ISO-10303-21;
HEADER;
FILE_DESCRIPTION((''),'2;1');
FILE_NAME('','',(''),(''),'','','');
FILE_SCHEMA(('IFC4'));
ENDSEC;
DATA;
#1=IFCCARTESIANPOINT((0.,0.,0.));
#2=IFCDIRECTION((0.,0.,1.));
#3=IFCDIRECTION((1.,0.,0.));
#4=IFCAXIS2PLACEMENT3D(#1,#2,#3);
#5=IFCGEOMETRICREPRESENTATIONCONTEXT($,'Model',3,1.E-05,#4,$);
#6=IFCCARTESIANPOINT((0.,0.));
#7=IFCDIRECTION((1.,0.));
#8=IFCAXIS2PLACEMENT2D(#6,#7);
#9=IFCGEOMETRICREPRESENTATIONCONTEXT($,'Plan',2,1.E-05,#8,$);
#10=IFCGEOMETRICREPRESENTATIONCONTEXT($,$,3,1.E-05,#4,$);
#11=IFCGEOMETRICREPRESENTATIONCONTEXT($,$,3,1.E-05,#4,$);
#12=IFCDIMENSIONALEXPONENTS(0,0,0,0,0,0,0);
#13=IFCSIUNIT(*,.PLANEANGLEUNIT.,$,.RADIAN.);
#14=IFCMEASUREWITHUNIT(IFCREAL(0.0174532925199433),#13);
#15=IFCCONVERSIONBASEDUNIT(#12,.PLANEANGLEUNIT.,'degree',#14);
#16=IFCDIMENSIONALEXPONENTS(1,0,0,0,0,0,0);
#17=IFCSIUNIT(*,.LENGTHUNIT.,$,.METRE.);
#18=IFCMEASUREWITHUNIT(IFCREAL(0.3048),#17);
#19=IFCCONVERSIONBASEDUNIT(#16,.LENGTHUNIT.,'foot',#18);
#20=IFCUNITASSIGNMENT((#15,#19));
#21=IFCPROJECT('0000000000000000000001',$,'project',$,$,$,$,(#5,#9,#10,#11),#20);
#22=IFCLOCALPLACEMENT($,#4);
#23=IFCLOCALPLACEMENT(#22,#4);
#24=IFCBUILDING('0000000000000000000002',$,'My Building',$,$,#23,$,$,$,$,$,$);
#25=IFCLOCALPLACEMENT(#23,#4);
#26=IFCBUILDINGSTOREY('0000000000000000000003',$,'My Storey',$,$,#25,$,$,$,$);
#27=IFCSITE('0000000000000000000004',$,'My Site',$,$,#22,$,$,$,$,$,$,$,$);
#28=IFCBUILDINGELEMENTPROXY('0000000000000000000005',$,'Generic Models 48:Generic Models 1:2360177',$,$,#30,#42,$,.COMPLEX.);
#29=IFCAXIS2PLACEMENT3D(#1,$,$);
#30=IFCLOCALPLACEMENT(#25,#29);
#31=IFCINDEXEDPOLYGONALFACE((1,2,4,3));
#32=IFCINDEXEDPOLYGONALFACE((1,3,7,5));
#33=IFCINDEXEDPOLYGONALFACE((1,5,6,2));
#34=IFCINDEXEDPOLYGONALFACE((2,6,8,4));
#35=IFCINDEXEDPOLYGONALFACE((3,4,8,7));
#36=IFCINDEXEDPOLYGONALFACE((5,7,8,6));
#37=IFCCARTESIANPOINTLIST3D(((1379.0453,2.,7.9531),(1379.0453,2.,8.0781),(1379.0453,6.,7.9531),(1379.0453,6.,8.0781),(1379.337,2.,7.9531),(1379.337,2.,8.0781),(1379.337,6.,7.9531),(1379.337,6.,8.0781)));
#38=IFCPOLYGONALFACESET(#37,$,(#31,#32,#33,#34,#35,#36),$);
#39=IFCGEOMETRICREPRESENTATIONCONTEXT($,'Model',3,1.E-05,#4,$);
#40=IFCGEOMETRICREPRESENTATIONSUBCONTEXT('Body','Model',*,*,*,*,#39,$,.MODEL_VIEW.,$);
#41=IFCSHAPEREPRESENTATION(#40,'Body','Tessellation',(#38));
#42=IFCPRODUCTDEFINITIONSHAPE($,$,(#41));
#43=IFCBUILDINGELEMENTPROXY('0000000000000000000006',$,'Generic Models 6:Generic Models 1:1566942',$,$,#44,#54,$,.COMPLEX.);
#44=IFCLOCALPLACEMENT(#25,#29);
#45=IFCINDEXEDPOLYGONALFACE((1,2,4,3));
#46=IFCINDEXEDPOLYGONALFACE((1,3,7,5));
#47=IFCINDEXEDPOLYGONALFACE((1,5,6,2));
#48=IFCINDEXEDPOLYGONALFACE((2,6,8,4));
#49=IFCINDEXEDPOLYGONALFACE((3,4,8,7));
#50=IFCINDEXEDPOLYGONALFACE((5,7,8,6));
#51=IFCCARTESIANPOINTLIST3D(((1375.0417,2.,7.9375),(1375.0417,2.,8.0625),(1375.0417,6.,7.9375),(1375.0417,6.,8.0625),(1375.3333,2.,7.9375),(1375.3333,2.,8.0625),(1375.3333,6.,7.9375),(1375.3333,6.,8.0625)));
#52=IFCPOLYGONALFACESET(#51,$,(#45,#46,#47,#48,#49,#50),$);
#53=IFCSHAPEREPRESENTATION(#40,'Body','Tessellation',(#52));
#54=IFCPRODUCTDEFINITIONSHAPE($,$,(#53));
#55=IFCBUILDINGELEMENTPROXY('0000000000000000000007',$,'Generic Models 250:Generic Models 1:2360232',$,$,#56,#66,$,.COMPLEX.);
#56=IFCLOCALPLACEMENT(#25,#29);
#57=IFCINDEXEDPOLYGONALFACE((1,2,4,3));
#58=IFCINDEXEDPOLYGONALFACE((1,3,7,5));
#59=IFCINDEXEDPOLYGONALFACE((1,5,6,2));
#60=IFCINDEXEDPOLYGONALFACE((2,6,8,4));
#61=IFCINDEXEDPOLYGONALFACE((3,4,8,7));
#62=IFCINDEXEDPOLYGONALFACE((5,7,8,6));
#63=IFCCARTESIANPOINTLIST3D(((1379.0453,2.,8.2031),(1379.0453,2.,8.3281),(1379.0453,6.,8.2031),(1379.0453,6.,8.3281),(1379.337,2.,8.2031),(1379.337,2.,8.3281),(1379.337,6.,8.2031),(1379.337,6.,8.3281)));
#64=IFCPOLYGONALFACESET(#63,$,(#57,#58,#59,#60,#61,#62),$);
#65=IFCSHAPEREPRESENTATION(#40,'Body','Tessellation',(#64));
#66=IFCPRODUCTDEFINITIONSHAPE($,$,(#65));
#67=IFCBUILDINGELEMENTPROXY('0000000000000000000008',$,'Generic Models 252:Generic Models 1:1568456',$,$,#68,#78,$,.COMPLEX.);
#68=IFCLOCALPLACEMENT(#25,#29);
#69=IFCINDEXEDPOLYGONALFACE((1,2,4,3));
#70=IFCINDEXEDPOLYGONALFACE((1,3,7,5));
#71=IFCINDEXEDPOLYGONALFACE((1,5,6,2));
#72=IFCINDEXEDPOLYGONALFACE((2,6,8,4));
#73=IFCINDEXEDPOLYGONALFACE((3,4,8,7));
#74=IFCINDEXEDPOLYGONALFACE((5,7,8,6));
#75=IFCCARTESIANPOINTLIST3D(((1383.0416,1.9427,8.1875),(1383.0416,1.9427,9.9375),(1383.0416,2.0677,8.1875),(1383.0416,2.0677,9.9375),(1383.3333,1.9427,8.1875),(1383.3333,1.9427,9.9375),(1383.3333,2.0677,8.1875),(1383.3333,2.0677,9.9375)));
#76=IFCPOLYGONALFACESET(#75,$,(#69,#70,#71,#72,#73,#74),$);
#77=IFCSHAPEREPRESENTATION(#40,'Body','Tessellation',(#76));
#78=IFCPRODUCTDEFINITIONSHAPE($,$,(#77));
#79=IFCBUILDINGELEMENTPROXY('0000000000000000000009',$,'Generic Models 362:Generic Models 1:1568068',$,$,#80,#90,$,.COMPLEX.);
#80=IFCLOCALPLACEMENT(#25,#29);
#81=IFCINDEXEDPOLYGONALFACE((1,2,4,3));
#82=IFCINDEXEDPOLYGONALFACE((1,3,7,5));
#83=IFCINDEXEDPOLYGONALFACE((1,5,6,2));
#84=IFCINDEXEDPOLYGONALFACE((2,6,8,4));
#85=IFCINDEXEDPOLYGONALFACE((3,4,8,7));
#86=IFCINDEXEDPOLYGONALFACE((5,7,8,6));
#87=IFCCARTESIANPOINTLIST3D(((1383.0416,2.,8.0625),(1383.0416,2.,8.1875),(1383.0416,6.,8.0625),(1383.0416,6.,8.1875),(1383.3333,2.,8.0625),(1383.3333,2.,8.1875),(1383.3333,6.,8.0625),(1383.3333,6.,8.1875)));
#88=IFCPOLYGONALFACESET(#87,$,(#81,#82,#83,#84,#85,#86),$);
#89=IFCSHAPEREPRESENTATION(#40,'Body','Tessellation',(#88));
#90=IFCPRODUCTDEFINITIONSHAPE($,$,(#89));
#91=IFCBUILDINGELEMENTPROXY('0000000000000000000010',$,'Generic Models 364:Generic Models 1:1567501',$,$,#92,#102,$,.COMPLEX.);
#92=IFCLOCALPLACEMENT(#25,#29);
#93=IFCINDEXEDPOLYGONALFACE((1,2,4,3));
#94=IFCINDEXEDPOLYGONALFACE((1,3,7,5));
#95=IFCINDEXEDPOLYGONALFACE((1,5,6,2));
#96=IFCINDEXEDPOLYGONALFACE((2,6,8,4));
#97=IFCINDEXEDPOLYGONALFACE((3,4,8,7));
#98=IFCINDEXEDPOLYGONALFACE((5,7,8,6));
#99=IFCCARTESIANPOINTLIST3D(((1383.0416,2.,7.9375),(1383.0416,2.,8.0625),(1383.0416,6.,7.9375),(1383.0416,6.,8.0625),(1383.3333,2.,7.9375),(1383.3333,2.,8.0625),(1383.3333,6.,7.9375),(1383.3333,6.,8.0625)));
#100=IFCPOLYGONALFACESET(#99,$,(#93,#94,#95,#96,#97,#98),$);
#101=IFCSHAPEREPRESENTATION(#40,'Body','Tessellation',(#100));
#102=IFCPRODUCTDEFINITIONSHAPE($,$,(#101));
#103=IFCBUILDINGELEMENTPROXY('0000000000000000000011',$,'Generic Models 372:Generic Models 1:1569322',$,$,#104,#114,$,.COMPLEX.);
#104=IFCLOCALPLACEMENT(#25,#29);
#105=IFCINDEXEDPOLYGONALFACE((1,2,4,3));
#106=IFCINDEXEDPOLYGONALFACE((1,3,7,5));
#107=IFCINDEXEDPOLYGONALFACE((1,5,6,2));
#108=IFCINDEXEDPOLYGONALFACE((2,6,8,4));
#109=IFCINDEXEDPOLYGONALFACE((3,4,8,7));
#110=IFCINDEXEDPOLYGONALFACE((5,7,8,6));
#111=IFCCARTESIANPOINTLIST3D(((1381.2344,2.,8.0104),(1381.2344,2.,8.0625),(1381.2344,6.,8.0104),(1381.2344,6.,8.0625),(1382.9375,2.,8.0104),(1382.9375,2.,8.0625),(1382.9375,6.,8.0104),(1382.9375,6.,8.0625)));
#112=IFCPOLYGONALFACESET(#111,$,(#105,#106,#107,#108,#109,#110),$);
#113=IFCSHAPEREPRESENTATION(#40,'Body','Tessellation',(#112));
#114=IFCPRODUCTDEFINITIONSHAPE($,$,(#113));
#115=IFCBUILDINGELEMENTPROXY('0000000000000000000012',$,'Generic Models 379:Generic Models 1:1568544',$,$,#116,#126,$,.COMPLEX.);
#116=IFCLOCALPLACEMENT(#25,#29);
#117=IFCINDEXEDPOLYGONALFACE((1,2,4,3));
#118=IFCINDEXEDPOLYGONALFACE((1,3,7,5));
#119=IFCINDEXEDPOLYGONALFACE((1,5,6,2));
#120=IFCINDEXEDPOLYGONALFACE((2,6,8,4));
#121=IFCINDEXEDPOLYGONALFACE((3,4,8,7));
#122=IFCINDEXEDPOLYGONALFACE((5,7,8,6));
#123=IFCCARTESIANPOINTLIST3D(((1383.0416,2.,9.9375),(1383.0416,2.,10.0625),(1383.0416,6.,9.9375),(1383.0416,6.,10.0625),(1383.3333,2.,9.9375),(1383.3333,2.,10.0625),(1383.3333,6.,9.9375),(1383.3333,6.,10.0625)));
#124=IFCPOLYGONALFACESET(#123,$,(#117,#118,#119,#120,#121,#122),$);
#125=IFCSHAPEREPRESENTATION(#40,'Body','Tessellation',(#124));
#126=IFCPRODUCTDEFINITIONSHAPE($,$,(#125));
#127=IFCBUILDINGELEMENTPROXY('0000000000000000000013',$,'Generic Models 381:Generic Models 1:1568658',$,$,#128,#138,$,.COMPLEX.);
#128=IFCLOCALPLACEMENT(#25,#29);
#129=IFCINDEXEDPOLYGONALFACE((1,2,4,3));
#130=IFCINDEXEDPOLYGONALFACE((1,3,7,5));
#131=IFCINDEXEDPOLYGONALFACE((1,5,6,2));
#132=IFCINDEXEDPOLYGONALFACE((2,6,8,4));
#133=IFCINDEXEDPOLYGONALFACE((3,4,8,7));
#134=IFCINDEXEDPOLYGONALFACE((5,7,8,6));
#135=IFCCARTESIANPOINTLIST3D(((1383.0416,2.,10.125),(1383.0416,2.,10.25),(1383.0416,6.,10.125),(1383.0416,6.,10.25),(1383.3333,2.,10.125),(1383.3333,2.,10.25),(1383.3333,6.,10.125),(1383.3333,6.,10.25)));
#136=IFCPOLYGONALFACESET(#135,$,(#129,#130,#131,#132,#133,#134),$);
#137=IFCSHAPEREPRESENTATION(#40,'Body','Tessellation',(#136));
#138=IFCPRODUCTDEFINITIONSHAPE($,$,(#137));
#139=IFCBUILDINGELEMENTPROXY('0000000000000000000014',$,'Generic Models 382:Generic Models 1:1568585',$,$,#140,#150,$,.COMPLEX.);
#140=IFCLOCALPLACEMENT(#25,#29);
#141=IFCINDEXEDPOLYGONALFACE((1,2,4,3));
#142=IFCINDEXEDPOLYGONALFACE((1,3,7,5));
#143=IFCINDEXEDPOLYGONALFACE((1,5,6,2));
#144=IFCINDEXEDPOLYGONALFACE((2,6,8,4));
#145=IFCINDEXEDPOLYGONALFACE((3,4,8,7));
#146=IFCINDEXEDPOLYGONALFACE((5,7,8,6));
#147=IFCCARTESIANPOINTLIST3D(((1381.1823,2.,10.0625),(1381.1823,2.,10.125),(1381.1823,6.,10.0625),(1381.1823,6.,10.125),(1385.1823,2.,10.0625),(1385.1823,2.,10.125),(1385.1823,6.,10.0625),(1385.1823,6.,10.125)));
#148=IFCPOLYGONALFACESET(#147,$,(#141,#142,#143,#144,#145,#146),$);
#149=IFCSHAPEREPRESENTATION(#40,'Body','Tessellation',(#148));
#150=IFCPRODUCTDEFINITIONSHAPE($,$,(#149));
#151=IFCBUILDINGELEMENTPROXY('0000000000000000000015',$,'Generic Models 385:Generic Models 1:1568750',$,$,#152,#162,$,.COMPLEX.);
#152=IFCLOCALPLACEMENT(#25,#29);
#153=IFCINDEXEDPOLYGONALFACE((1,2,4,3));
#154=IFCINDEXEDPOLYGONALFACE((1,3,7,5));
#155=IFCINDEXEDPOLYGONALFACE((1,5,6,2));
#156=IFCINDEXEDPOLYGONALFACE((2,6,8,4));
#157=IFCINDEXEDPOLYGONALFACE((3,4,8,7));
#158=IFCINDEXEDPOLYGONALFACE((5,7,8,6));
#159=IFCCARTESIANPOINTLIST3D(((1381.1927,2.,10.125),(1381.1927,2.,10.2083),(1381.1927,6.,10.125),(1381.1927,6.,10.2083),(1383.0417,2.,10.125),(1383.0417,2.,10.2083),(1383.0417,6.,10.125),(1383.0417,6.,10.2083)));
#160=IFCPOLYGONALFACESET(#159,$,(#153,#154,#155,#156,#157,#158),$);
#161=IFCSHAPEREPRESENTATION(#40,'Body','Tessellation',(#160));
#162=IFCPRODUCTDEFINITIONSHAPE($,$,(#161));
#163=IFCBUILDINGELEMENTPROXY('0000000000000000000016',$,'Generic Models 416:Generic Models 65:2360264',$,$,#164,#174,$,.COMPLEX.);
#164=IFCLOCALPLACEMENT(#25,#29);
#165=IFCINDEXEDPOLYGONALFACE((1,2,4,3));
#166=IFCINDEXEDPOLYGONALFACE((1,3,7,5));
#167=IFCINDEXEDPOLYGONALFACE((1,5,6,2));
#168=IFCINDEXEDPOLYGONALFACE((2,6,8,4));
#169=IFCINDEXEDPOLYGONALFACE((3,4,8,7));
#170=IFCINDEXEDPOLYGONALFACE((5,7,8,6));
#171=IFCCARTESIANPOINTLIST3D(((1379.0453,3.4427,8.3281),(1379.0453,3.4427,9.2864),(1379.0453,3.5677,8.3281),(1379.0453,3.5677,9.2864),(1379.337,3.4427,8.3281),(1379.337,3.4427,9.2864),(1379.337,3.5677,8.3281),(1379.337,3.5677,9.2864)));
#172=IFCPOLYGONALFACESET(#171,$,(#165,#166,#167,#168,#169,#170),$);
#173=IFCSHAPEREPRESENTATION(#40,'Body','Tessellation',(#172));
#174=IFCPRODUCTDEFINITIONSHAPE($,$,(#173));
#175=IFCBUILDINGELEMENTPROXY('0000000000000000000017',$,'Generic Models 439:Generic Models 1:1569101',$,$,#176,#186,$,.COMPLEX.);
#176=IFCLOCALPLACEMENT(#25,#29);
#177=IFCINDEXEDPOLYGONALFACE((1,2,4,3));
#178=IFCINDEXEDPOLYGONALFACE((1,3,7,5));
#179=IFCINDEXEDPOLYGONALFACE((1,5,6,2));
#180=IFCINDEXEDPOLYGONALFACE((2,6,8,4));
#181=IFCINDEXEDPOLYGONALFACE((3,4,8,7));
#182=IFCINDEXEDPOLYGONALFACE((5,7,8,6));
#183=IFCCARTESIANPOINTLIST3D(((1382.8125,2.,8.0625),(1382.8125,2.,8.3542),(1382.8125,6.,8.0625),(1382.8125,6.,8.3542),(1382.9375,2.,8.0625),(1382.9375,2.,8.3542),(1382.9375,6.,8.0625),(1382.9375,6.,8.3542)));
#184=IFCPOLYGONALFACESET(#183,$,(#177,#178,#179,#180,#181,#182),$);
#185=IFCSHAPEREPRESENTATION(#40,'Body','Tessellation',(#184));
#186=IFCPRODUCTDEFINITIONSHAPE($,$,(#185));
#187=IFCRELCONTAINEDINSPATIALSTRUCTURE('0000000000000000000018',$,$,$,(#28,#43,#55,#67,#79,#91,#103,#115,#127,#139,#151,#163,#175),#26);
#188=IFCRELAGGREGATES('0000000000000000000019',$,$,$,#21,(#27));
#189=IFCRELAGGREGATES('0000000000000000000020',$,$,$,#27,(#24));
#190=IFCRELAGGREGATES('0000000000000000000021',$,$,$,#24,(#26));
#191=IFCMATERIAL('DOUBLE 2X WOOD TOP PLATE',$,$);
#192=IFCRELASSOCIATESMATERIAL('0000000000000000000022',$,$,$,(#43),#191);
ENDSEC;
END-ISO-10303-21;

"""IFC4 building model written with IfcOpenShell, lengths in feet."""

from ifc_helpers import new_model, entity, si_unit, converted_unit, frame, origin_with_axes, origin_2d_with_axis, place, context, subcontext, project, spatial, polyline, outline, extrude, material, element, save


model = new_model("IFC4")

# Units and contexts
model_context_1 = context("Model", 3, precision=1e-05, world=origin_with_axes())
plan_context = context("Plan", 2, precision=1e-05, world=origin_2d_with_axis())
model_context_2 = context("Model", 3, precision=1e-05, world=origin_with_axes())
context_of_model_1 = context(None, 3, precision=1e-05, world=origin_with_axes())
context_of_model_2 = context(None, 3, precision=1e-05, world=origin_with_axes())
body_context = subcontext(model_context_2, "Body", "Model", "MODEL_VIEW")
ifc_project = project(units=[converted_unit("PLANEANGLEUNIT", "degree", entity("IfcReal", 0.0174532925199433), si_unit("PLANEANGLEUNIT", "RADIAN"), dimensions=[0, 0, 0, 0, 0, 0, 0]), converted_unit("LENGTHUNIT", "foot", entity("IfcReal", 0.3048), si_unit("LENGTHUNIT", "METRE"), dimensions=[1, 0, 0, 0, 0, 0, 0])], contexts=[model_context_1, plan_context, context_of_model_1, context_of_model_2])

# Site, building, storey
site_placement = place(None, origin_with_axes())
site = spatial("IfcSite", under=ifc_project, at=site_placement, Name="My Site")
building_placement = place(site_placement, origin_with_axes())
building = spatial("IfcBuilding", under=site, at=building_placement, Name="My Building")
storey_placement = place(building_placement, origin_with_axes())
storey = spatial("IfcBuildingStorey", under=building, at=storey_placement, Name="My Storey")

# Building element proxies
proxy_1_placement = place(storey_placement, frame((1379.0453, 6.0, 7.9531), z_axis=(0.0, -1.0, 0.0), x_axis=(0.0, 0.0, 1.0)))
element("IfcBuildingElementProxy", 1, at=proxy_1_placement, inside=storey, Name="Generic Models 48:Generic Models 1:2360177", PredefinedType="COMPLEX", context=body_context, shape_type="SweptSolid", body=[
    extrude(outline(polyline([(-0.1458, -0.0625), (0.1458, -0.0625), (0.1458, 0.0625), (-0.1458, 0.0625), (-0.1458, -0.0625)])), frame((0.0625, -0.1458, 0.0), z_axis=(0.0, 0.0, -1.0), x_axis=(0.0, 1.0, 0.0)), (0.0, 0.0, -1.0), 4.0),
])
ifc_material_1 = material(Name="DOUBLE 2X WOOD TOP PLATE")
proxy_2_placement = place(storey_placement, frame((1375.0417, 6.0, 7.9375), z_axis=(0.0, -1.0, 0.0), x_axis=(0.0, 0.0, -1.0)))
element("IfcBuildingElementProxy", 2, at=proxy_2_placement, inside=storey, material=ifc_material_1, Name="Generic Models 6:Generic Models 1:1566942", PredefinedType="COMPLEX", context=body_context, shape_type="SweptSolid", body=[
    extrude(outline(polyline([(-0.0625, -0.1458), (0.0625, -0.1458), (0.0625, 0.1458), (-0.0625, 0.1458), (-0.0625, -0.1458)])), frame((-0.0625, 0.1458, 0.0), z_axis=(0.0, 0.0, -1.0), x_axis=(-1.0, 0.0, 0.0)), (0.0, 0.0, -1.0), 4.0),
])
proxy_3_placement = place(storey_placement, frame((1379.0453, 6.0, 8.2031), z_axis=(0.0, -1.0, 0.0), x_axis=(0.0, 0.0, 1.0)))
element("IfcBuildingElementProxy", 3, at=proxy_3_placement, inside=storey, Name="Generic Models 250:Generic Models 1:2360232", PredefinedType="COMPLEX", context=body_context, shape_type="SweptSolid", body=[
    extrude(outline(polyline([(-0.0625, -0.1458), (0.0625, -0.1458), (0.0625, 0.1458), (-0.0625, 0.1458), (-0.0625, -0.1458)])), frame((0.0625, -0.1458, 0.0), z_axis=(0.0, 0.0, -1.0), x_axis=(-1.0, 0.0, 0.0)), (0.0, 0.0, -1.0), 4.0),
])
proxy_4_placement = place(storey_placement, frame((1383.0416, 1.9427, 8.1875), z_axis=(0.0, 0.0, 1.0), x_axis=(1.0, 0.0, 0.0)))
element("IfcBuildingElementProxy", 4, at=proxy_4_placement, inside=storey, Name="Generic Models 252:Generic Models 1:1568456", PredefinedType="COMPLEX", context=body_context, shape_type="SweptSolid", body=[
    extrude(outline(polyline([(-0.1458, -0.0625), (0.1458, -0.0625), (0.1458, 0.0625), (-0.1458, 0.0625), (-0.1458, -0.0625)])), frame((0.1458, 0.0625, 0.0), z_axis=(0.0, 0.0, -1.0), x_axis=(-1.0, 0.0, 0.0)), (0.0, 0.0, -1.0), 1.75),
])
proxy_5_placement = place(storey_placement, frame((1383.0416, 6.0, 8.0625), z_axis=(0.0, -1.0, 0.0), x_axis=(0.0, 0.0, 1.0)))
element("IfcBuildingElementProxy", 5, at=proxy_5_placement, inside=storey, Name="Generic Models 362:Generic Models 1:1568068", PredefinedType="COMPLEX", context=body_context, shape_type="SweptSolid", body=[
    extrude(outline(polyline([(-0.0625, -0.1458), (0.0625, -0.1458), (0.0625, 0.1458), (-0.0625, 0.1458), (-0.0625, -0.1458)])), frame((0.0625, -0.1458, 0.0), z_axis=(0.0, 0.0, -1.0), x_axis=(-1.0, 0.0, 0.0)), (0.0, 0.0, -1.0), 4.0),
])
proxy_6_placement = place(storey_placement, frame((1383.0416, 6.0, 7.9375), z_axis=(0.0, -1.0, 0.0), x_axis=(0.0, 0.0, 1.0)))
element("IfcBuildingElementProxy", 6, at=proxy_6_placement, inside=storey, Name="Generic Models 364:Generic Models 1:1567501", PredefinedType="COMPLEX", context=body_context, shape_type="SweptSolid", body=[
    extrude(outline(polyline([(-0.1458, -0.0625), (0.1458, -0.0625), (0.1458, 0.0625), (-0.1458, 0.0625), (-0.1458, -0.0625)])), frame((0.0625, -0.1458, 0.0), z_axis=(0.0, 0.0, -1.0), x_axis=(0.0, 1.0, 0.0)), (0.0, 0.0, -1.0), 4.0),
])
proxy_7_placement = place(storey_placement, frame((1381.2344, 6.0, 8.0104), z_axis=(0.0, -1.0, 0.0), x_axis=(0.0, 0.0, 1.0)))
element("IfcBuildingElementProxy", 7, at=proxy_7_placement, inside=storey, Name="Generic Models 372:Generic Models 1:1569322", PredefinedType="COMPLEX", context=body_context, shape_type="SweptSolid", body=[
    extrude(outline(polyline([(-0.026, -0.8516), (0.026, -0.8516), (0.026, 0.8516), (-0.026, 0.8516), (-0.026, -0.8516)])), frame((0.026, -0.8516, 0.0), z_axis=(0.0, 0.0, -1.0), x_axis=(1.0, 0.0, 0.0)), (0.0, 0.0, -1.0), 4.0),
])
for number, where, z_axis, x_axis, name in (
    (8, (1383.0416, 6.0, 9.9375), (0.0, -1.0, 0.0), (0.0, 0.0, 1.0), "Generic Models 379:Generic Models 1:1568544"),
    (9, (1383.0416, 6.0, 10.125), (0.0, -1.0, 0.0), (0.0, 0.0, 1.0), "Generic Models 381:Generic Models 1:1568658"),
):
    element("IfcBuildingElementProxy", number, at=place(storey_placement, frame(where, z_axis=z_axis, x_axis=x_axis)), inside=storey, Name=name, PredefinedType="COMPLEX", context=body_context, shape_type="SweptSolid", body=[
        extrude(outline(polyline([(-0.1458, -0.0625), (0.1458, -0.0625), (0.1458, 0.0625), (-0.1458, 0.0625), (-0.1458, -0.0625)])), frame((0.0625, -0.1458, 0.0), z_axis=(0.0, 0.0, -1.0), x_axis=(0.0, 1.0, 0.0)), (0.0, 0.0, -1.0), 4.0),
    ])
proxy_8_placement = place(storey_placement, frame((1381.1823, 6.0, 10.0625), z_axis=(0.0, -1.0, 0.0), x_axis=(0.0, 0.0, 1.0)))
element("IfcBuildingElementProxy", 10, at=proxy_8_placement, inside=storey, Name="Generic Models 382:Generic Models 1:1568585", PredefinedType="COMPLEX", context=body_context, shape_type="SweptSolid", body=[
    extrude(outline(polyline([(-0.0313, -2.0), (0.0312, -2.0), (0.0313, 2.0), (-0.0312, 2.0), (-0.0313, -2.0)])), frame((0.0313, -2.0, 0.0), z_axis=(0.0, 0.0, -1.0), x_axis=(-1.0, 0.0, 0.0)), (0.0, 0.0, -1.0), 4.0),
])
proxy_9_placement = place(storey_placement, frame((1381.1927, 6.0, 10.125), z_axis=(0.0, -1.0, 0.0), x_axis=(0.0, 0.0, 1.0)))
element("IfcBuildingElementProxy", 11, at=proxy_9_placement, inside=storey, Name="Generic Models 385:Generic Models 1:1568750", PredefinedType="COMPLEX", context=body_context, shape_type="SweptSolid", body=[
    extrude(outline(polyline([(-0.0417, -0.9245), (0.0417, -0.9245), (0.0417, 0.9245), (-0.0417, 0.9245), (-0.0417, -0.9245)])), frame((0.0417, -0.9245, 0.0), z_axis=(0.0, 0.0, -1.0), x_axis=(1.0, 0.0, 0.0)), (0.0, 0.0, -1.0), 4.0),
])
proxy_10_placement = place(storey_placement, frame((1379.0453, 3.4427, 8.3281), z_axis=(0.0, 0.0, 1.0), x_axis=(1.0, 0.0, 0.0)))
element("IfcBuildingElementProxy", 12, at=proxy_10_placement, inside=storey, Name="Generic Models 416:Generic Models 65:2360264", PredefinedType="COMPLEX", context=body_context, shape_type="SweptSolid", body=[
    extrude(outline(polyline([(-0.1458, -0.0625), (0.1458, -0.0625), (0.1458, 0.0625), (-0.1458, 0.0625), (-0.1458, -0.0625)])), frame((0.1458, 0.0625, 0.0), z_axis=(0.0, 0.0, -1.0), x_axis=(-1.0, 0.0, 0.0)), (0.0, 0.0, -1.0), 0.9583),
])
proxy_11_placement = place(storey_placement, frame((1382.8125, 6.0, 8.0625), z_axis=(0.0, -1.0, 0.0), x_axis=(0.0, 0.0, 1.0)))
element("IfcBuildingElementProxy", 13, at=proxy_11_placement, inside=storey, Name="Generic Models 439:Generic Models 1:1569101", PredefinedType="COMPLEX", context=body_context, shape_type="SweptSolid", body=[
    extrude(outline(polyline([(-0.0625, -0.1458), (0.0625, -0.1458), (0.0625, 0.1458), (-0.0625, 0.1458), (-0.0625, -0.1458)])), frame((0.1458, -0.0625, 0.0), z_axis=(0.0, 0.0, -1.0), x_axis=(0.0, 1.0, 0.0)), (0.0, 0.0, -1.0), 4.0),
])

save(model, "model.ifc")
